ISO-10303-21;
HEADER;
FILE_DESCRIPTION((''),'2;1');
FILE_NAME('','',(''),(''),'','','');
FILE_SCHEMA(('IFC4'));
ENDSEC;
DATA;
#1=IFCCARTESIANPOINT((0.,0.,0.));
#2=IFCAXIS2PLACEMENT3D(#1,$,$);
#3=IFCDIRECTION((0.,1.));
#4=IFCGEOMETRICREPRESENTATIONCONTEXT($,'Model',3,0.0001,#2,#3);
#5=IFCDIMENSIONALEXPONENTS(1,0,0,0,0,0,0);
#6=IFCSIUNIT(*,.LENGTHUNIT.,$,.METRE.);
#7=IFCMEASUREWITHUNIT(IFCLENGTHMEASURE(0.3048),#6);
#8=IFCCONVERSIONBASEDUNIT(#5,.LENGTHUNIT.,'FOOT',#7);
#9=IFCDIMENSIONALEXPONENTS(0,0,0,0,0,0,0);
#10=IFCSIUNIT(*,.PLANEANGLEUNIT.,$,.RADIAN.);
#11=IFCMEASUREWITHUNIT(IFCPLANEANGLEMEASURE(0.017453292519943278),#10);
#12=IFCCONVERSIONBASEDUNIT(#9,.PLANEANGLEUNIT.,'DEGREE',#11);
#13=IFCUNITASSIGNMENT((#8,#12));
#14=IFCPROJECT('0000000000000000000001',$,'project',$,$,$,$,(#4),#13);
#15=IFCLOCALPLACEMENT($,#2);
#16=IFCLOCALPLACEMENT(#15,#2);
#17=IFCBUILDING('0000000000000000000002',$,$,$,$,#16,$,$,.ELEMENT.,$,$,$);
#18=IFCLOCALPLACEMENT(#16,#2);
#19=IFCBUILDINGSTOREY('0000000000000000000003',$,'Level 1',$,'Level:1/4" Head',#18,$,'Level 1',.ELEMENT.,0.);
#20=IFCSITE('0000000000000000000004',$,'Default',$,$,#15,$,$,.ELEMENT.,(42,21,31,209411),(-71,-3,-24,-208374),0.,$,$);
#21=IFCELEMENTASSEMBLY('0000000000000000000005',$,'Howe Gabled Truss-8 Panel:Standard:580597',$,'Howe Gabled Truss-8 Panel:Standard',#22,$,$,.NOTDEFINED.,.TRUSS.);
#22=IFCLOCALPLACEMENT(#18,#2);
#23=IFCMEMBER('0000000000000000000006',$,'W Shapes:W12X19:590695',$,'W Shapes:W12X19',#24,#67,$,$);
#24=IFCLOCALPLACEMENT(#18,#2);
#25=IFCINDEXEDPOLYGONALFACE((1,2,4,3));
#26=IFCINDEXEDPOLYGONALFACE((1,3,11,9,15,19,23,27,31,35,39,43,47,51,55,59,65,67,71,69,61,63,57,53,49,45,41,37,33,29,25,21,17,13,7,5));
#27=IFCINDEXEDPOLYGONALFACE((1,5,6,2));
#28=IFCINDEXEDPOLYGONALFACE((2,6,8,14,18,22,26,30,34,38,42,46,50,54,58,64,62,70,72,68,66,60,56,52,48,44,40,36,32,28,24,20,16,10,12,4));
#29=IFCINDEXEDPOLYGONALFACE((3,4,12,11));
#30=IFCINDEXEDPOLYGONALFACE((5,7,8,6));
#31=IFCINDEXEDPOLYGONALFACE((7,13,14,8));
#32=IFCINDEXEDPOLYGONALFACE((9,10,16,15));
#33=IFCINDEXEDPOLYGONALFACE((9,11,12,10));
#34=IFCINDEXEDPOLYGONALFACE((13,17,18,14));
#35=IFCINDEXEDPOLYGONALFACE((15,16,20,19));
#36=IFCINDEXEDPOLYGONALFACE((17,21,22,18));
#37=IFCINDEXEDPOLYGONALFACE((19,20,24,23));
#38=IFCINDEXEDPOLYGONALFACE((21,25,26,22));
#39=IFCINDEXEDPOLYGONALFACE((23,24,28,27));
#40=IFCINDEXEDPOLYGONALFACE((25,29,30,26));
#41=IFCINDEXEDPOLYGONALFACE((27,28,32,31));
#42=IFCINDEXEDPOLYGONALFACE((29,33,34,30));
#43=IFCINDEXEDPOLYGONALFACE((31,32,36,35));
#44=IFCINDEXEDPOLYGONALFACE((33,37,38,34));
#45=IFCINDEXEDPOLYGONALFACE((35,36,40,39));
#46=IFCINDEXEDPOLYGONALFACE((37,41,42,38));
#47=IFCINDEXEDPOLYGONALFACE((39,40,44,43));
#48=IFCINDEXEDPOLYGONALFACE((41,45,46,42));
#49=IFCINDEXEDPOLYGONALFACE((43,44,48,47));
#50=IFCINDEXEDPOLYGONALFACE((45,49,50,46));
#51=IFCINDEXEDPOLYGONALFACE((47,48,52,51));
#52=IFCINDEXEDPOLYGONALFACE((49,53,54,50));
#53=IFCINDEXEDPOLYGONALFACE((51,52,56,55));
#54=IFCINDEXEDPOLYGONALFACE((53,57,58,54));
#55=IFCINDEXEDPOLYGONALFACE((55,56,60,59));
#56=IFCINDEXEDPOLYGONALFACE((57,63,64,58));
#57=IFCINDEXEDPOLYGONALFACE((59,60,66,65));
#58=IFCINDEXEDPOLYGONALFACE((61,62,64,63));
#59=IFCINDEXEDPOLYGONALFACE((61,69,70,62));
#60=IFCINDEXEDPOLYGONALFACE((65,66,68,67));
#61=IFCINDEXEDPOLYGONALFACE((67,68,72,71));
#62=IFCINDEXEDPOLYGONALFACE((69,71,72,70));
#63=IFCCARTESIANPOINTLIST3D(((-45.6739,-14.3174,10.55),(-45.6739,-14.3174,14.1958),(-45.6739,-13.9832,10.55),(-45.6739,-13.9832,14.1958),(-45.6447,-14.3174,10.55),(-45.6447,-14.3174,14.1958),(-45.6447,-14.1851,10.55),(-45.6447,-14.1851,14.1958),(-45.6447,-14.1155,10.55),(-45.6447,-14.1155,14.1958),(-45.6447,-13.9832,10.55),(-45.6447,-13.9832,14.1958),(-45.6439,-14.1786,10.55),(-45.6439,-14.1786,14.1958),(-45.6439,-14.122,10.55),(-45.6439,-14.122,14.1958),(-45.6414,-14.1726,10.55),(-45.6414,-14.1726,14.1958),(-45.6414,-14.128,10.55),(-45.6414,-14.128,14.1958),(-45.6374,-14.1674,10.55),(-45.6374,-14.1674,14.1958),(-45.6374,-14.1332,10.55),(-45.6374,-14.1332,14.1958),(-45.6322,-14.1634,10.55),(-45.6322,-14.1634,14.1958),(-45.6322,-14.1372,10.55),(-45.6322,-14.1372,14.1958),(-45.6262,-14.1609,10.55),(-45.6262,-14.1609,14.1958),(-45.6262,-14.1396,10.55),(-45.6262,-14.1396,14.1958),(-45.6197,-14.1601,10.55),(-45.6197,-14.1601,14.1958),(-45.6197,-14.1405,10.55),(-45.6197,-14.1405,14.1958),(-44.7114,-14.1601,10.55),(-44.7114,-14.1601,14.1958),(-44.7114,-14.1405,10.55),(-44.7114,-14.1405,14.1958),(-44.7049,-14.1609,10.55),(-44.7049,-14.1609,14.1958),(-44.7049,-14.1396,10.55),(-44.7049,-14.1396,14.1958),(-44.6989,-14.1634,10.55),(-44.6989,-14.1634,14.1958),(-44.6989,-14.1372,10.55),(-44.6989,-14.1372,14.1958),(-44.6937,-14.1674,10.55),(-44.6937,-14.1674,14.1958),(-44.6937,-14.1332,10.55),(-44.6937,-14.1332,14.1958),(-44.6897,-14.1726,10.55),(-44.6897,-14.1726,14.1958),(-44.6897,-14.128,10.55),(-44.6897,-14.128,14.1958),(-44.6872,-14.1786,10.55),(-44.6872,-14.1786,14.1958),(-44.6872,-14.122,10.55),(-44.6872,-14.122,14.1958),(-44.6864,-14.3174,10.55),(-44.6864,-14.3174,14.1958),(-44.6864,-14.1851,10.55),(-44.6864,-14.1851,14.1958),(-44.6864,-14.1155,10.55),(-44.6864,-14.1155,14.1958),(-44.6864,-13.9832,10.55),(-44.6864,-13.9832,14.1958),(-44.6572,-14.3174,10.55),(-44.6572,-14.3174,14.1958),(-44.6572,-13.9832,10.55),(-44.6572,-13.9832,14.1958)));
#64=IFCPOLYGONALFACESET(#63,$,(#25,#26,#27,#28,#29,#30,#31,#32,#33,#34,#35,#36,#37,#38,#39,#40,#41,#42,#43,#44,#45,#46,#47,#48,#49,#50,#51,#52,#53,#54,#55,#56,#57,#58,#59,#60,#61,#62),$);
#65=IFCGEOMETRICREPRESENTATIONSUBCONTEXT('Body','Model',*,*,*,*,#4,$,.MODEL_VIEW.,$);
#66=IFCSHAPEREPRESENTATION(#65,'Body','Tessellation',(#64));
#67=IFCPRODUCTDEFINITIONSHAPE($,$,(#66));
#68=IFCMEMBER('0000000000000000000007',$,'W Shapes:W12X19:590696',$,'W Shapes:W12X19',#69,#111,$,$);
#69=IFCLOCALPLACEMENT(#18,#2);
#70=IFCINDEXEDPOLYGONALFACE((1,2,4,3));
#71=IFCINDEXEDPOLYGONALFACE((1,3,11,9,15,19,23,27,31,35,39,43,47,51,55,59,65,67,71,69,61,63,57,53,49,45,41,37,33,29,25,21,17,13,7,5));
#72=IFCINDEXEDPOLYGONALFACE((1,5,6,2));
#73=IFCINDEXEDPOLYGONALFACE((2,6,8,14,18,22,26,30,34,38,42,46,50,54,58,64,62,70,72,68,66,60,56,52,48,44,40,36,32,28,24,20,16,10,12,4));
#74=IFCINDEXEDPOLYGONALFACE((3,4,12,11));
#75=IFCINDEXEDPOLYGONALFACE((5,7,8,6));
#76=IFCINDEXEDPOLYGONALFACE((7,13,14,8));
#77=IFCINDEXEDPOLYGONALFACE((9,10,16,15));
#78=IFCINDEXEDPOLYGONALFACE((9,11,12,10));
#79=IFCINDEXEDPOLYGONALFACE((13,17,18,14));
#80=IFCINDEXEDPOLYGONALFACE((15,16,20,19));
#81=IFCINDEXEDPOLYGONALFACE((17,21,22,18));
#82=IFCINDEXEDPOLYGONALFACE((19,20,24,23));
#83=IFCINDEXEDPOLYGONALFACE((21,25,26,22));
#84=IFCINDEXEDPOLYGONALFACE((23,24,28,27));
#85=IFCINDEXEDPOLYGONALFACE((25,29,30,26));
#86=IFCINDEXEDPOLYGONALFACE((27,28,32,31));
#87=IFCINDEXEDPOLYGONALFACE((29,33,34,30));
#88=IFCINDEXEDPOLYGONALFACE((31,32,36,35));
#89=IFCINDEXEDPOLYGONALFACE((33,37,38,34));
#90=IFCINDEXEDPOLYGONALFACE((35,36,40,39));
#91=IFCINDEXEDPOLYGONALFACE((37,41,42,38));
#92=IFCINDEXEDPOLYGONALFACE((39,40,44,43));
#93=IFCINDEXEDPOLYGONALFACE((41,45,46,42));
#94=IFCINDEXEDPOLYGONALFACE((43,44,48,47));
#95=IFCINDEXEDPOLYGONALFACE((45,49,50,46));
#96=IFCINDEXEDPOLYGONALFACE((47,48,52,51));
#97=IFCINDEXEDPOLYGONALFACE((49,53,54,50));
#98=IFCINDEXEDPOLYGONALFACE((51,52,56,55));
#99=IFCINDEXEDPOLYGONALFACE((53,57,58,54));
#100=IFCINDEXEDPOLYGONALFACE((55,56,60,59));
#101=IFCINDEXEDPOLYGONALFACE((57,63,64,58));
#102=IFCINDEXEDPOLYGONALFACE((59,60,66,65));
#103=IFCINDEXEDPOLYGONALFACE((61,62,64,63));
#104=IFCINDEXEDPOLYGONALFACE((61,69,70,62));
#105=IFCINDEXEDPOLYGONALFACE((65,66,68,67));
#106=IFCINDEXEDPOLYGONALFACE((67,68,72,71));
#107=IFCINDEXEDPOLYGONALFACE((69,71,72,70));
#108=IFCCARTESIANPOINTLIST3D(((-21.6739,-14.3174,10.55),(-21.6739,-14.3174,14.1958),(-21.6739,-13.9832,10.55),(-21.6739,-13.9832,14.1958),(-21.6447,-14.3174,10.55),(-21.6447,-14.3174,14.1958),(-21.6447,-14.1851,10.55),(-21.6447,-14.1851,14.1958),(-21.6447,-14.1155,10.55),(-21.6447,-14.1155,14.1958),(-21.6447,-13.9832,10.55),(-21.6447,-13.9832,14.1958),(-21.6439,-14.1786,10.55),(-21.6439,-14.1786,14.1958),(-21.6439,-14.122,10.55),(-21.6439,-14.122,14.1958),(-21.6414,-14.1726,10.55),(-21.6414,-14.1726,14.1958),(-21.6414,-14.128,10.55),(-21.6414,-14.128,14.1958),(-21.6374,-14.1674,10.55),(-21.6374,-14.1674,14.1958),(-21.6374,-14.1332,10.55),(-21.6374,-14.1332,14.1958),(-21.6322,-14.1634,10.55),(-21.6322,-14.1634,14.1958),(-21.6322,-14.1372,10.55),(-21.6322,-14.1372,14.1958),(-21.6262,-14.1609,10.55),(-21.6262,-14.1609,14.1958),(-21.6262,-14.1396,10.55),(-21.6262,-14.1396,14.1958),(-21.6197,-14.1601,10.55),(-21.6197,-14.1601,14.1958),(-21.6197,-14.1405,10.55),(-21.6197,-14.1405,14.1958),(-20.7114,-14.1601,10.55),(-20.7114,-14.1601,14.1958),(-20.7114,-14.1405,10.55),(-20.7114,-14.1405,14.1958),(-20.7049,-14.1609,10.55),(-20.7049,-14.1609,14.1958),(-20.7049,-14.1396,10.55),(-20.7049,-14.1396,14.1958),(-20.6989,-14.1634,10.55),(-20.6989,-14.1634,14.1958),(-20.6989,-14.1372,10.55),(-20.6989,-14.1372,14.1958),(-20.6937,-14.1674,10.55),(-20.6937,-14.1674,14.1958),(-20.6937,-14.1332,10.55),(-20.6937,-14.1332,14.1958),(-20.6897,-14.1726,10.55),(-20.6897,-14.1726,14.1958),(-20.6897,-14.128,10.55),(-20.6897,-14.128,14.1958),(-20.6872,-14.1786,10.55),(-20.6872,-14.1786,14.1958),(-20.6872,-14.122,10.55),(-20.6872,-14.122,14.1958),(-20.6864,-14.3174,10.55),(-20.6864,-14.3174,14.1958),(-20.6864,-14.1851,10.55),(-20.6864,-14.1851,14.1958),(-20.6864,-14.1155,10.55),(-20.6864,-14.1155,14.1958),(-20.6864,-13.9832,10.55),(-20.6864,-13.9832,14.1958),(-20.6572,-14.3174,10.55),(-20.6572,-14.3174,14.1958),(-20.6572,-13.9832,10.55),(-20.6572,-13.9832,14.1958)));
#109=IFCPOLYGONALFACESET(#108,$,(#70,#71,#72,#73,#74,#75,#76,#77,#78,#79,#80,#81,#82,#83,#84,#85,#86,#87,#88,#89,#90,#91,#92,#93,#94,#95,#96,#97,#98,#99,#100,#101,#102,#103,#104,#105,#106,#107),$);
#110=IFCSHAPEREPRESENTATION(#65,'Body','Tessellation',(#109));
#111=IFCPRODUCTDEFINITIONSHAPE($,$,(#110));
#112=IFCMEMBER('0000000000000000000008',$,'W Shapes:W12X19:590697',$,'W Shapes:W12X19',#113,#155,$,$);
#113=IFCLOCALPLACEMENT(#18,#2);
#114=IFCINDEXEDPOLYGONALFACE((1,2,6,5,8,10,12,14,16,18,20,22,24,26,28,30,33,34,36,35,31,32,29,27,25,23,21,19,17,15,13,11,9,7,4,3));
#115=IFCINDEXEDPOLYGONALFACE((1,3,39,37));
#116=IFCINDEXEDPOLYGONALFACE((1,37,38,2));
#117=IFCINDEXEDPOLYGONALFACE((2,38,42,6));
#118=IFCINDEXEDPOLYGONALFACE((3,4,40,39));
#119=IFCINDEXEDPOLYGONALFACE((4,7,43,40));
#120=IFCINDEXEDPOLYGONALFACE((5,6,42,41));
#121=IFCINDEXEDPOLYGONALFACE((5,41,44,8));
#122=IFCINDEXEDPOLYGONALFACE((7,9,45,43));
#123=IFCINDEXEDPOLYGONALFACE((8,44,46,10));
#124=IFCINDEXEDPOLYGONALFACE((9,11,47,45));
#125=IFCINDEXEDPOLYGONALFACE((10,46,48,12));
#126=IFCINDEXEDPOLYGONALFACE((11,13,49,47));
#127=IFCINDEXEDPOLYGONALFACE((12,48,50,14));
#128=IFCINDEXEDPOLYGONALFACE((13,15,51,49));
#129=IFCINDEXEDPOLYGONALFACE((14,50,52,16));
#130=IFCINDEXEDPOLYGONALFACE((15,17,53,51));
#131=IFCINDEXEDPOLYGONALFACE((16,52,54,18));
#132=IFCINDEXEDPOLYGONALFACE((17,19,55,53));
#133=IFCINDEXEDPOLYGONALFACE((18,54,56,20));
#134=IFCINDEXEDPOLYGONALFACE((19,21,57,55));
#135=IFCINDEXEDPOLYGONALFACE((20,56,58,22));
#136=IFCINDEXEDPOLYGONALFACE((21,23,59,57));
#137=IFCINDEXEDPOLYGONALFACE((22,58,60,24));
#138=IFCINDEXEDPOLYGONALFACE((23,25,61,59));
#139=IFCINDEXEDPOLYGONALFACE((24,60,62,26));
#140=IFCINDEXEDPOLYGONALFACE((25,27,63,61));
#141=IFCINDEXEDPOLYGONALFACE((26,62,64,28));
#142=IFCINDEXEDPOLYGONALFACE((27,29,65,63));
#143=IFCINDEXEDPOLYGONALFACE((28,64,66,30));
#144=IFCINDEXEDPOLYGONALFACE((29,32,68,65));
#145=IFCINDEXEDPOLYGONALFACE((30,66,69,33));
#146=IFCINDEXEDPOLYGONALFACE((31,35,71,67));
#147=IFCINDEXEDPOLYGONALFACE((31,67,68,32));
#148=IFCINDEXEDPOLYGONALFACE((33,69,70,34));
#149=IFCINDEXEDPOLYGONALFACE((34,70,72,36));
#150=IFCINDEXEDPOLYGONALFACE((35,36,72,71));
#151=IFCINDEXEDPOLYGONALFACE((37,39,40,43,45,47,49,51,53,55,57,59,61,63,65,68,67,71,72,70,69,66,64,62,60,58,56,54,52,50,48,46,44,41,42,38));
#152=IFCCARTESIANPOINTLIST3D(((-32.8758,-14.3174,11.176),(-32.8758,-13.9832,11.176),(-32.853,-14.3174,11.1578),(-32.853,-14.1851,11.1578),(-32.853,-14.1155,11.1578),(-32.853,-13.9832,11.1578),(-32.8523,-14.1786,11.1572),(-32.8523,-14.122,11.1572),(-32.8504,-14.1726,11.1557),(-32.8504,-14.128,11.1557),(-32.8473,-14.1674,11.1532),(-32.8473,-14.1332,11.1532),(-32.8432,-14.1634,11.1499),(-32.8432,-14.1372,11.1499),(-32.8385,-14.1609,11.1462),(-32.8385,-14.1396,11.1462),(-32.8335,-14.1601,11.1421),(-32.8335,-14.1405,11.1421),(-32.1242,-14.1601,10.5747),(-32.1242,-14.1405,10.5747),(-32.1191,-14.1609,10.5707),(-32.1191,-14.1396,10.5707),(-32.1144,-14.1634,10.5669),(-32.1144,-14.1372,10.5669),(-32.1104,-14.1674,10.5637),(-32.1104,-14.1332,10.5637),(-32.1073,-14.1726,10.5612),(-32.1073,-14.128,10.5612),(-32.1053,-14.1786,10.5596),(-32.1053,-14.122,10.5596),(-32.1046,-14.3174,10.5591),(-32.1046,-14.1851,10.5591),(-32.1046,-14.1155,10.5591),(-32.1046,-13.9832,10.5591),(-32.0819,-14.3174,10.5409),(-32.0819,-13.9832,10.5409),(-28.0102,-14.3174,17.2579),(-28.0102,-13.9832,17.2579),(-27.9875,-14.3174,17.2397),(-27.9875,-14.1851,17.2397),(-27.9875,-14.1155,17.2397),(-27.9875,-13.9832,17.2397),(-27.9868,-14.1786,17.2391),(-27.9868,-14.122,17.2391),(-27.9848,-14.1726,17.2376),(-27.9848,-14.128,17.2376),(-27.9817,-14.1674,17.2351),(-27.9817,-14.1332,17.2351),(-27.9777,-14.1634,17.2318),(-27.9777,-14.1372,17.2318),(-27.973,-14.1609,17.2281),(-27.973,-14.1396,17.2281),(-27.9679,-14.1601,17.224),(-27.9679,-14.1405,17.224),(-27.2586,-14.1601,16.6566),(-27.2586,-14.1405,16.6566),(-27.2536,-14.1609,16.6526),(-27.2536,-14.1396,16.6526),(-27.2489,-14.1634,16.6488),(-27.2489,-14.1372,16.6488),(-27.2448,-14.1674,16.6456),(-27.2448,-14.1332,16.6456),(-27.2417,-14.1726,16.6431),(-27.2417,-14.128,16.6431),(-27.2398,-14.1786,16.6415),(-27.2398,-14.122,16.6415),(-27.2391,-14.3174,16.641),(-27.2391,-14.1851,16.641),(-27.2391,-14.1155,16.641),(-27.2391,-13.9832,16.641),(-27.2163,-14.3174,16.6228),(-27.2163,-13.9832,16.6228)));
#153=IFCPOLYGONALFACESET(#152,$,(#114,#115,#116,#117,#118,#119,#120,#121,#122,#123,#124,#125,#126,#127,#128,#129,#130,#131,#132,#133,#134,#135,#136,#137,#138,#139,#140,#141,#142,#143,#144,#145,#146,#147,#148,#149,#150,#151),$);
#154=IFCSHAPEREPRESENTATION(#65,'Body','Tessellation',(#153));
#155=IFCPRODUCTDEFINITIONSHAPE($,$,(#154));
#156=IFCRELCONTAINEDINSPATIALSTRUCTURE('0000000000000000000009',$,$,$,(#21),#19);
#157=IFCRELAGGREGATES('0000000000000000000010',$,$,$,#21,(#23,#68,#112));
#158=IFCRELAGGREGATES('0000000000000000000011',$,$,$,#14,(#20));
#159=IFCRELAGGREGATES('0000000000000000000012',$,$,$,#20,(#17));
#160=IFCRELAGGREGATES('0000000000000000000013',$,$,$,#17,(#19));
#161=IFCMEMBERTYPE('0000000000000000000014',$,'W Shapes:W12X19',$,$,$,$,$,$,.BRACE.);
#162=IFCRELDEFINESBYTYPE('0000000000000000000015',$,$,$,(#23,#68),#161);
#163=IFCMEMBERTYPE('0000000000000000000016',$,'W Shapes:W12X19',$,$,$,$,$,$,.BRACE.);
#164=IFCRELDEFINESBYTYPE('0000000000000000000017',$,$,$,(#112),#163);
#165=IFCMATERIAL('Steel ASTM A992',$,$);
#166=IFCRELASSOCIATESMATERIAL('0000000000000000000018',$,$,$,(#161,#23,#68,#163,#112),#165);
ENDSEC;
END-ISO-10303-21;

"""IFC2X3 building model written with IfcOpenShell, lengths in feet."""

from ifc_helpers import new_model, entity, si_unit, converted_unit, direction, frame, frame_2d, origin, place, context, subcontext, project, spatial, polyline, circle_curve, parameter, trimmed, segment, composite_curve, outline, extrude, source, transform, mapped, material, type_object, type_shapes, element, aggregate, save


model = new_model("IFC2X3")

# Units and contexts
model_context = context("Model", 3, precision=0.0001, world=origin(), true_north=direction((0.0, 1.0)))
body_context = subcontext(model_context, "Body", "Model", "MODEL_VIEW")
ifc_project = project(units=[converted_unit("LENGTHUNIT", "FOOT", entity("IfcLengthMeasure", 0.3048), si_unit("LENGTHUNIT", "METRE"), dimensions=[1, 0, 0, 0, 0, 0, 0]), converted_unit("PLANEANGLEUNIT", "DEGREE", entity("IfcPlaneAngleMeasure", 0.017453292519943278), si_unit("PLANEANGLEUNIT", "RADIAN"), dimensions=[0, 0, 0, 0, 0, 0, 0])], contexts=[model_context])

# Site, building, storey
site_placement = place(None, origin())
site = spatial("IfcSite", under=ifc_project, at=site_placement, Name="Default", CompositionType="ELEMENT", RefLatitude=(42, 21, 31, 209411), RefLongitude=(-71, -3, -24, -208374), RefElevation=0.0)
building_placement = place(site_placement, origin())
building = spatial("IfcBuilding", under=site, at=building_placement, CompositionType="ELEMENT")
storey_placement = place(building_placement, origin())
storey = spatial("IfcBuildingStorey", under=building, at=storey_placement, Name="Level 1", ObjectType="Level:1/4\" Head", LongName="Level 1", CompositionType="ELEMENT", Elevation=0.0)

# Element assembly, members
assembly_placement = place(storey_placement, origin())
assembly = element("IfcElementAssembly", 1, at=assembly_placement, inside=storey, Name="Howe Gabled Truss-8 Panel:Standard:580597", ObjectType="Howe Gabled Truss-8 Panel:Standard", AssemblyPlace="NOTDEFINED", PredefinedType="TRUSS")
ifc_material = material(Name="Steel ASTM A992")
member_type_1 = type_object("IfcMemberType", Name="W Shapes:W12X19", PredefinedType="BRACE", material=ifc_material)
shared_shape_1 = source(origin(), body_context, "Body", "SweptSolid", [
    extrude(outline(composite_curve([segment(polyline([(-0.1671, -0.4792), (-0.1671, -0.5083)]), True, "CONTINUOUS"), segment(polyline([(-0.1671, -0.5083), (0.1671, -0.5083)]), True, "CONTINUOUS"), segment(polyline([(0.1671, -0.5083), (0.1671, -0.4792)]), True, "CONTINUOUS"), segment(polyline([(0.1671, -0.4792), (0.0348, -0.4792)]), True, "CONTINUOUS"), segment(trimmed(circle_curve(frame_2d((0.0348, -0.4542), x_axis=(0.0, -1.0)), 0.025), [parameter(270.0)], [parameter(360.0)], True, "PARAMETER"), False, "CONTINUOUS"), segment(polyline([(0.0098, -0.4542), (0.0098, 0.4542)]), True, "CONTINUOUS"), segment(trimmed(circle_curve(frame_2d((0.0348, 0.4542), x_axis=(-1.0, 0.0)), 0.025), [parameter(270.0)], [parameter(360.0)], True, "PARAMETER"), False, "CONTINUOUS"), segment(polyline([(0.0348, 0.4792), (0.1671, 0.4792)]), True, "CONTINUOUS"), segment(polyline([(0.1671, 0.4792), (0.1671, 0.5083)]), True, "CONTINUOUS"), segment(polyline([(0.1671, 0.5083), (-0.1671, 0.5083)]), True, "CONTINUOUS"), segment(polyline([(-0.1671, 0.5083), (-0.1671, 0.4792)]), True, "CONTINUOUS"), segment(polyline([(-0.1671, 0.4792), (-0.0348, 0.4792)]), True, "CONTINUOUS"), segment(trimmed(circle_curve(frame_2d((-0.0348, 0.4542), x_axis=(0.0, 1.0)), 0.025), [parameter(270.0)], [parameter(0.0)], True, "PARAMETER"), False, "CONTINUOUS"), segment(polyline([(-0.0098, 0.4542), (-0.0098, -0.4542)]), True, "CONTINUOUS"), segment(trimmed(circle_curve(frame_2d((-0.0348, -0.4542), x_axis=(1.0, 0.0)), 0.025), [parameter(270.0)], [parameter(0.0)], True, "PARAMETER"), False, "CONTINUOUS"), segment(polyline([(-0.0348, -0.4792), (-0.1671, -0.4792)]), True, "CONTINUOUS")], self_intersect=False)), frame((-1.95, 0.0, 0.0), z_axis=(-1.0, 0.0, 0.0), x_axis=(0.0, -1.0, 0.0)), (0.0, 0.0, -1.0), 3.6458),
])
type_shapes(member_type_1, [shared_shape_1])
member_1_placement = place(assembly_placement, frame((-45.1655, -14.1503, 12.5), z_axis=(1.0, 0.0, 0.0), x_axis=(0.0, 0.0, 1.0)))
member_1 = element("IfcMember", 2, at=member_1_placement, type_object=member_type_1, material=ifc_material, Name="W Shapes:W12X19:590695", ObjectType="W Shapes:W12X19", context=body_context, shape_type="MappedRepresentation", body=[
    mapped(shared_shape_1, transform((0.0, 0.0, 0.0), scale=1.0)),
])
member_2_placement = place(assembly_placement, frame((-21.1655, -14.1503, 12.5), z_axis=(1.0, 0.0, 0.0), x_axis=(0.0, 0.0, 1.0)))
member_2 = element("IfcMember", 3, at=member_2_placement, type_object=member_type_1, material=ifc_material, Name="W Shapes:W12X19:590696", ObjectType="W Shapes:W12X19", context=body_context, shape_type="MappedRepresentation", body=[
    mapped(shared_shape_1, transform((0.0, 0.0, 0.0), scale=1.0)),
])
member_type_2 = type_object("IfcMemberType", Name="W Shapes:W12X19", PredefinedType="BRACE", material=ifc_material)
shared_shape_2 = source(origin(), body_context, "Body", "SweptSolid", [
    extrude(outline(composite_curve([segment(polyline([(-0.1671, -0.4792), (-0.1671, -0.5083)]), True, "CONTINUOUS"), segment(polyline([(-0.1671, -0.5083), (0.1671, -0.5083)]), True, "CONTINUOUS"), segment(polyline([(0.1671, -0.5083), (0.1671, -0.4792)]), True, "CONTINUOUS"), segment(polyline([(0.1671, -0.4792), (0.0348, -0.4792)]), True, "CONTINUOUS"), segment(trimmed(circle_curve(frame_2d((0.0348, -0.4542), x_axis=(1.0, 0.0)), 0.025), [parameter(180.0)], [parameter(270.0)], True, "PARAMETER"), False, "CONTINUOUS"), segment(polyline([(0.0098, -0.4542), (0.0098, 0.4542)]), True, "CONTINUOUS"), segment(trimmed(circle_curve(frame_2d((0.0348, 0.4542), x_axis=(1.0, 0.0)), 0.025), [parameter(90.0)], [parameter(180.0)], True, "PARAMETER"), False, "CONTINUOUS"), segment(polyline([(0.0348, 0.4792), (0.1671, 0.4792)]), True, "CONTINUOUS"), segment(polyline([(0.1671, 0.4792), (0.1671, 0.5083)]), True, "CONTINUOUS"), segment(polyline([(0.1671, 0.5083), (-0.1671, 0.5083)]), True, "CONTINUOUS"), segment(polyline([(-0.1671, 0.5083), (-0.1671, 0.4792)]), True, "CONTINUOUS"), segment(polyline([(-0.1671, 0.4792), (-0.0348, 0.4792)]), True, "CONTINUOUS"), segment(trimmed(circle_curve(frame_2d((-0.0348, 0.4542), x_axis=(1.0, 0.0)), 0.025), [parameter(360.0)], [parameter(90.0)], True, "PARAMETER"), False, "CONTINUOUS"), segment(polyline([(-0.0098, 0.4542), (-0.0098, -0.4542)]), True, "CONTINUOUS"), segment(trimmed(circle_curve(frame_2d((-0.0348, -0.4542), x_axis=(1.0, 0.0)), 0.025), [parameter(270.0)], [parameter(360.0)], True, "PARAMETER"), False, "CONTINUOUS"), segment(polyline([(-0.0348, -0.4792), (-0.1671, -0.4792)]), True, "CONTINUOUS")], self_intersect=False)), frame((-3.703, 0.0, 0.0), z_axis=(-1.0, 0.0, 0.0), x_axis=(0.0, -1.0, 0.0)), (0.0, 0.0, -1.0), 7.7886),
])
type_shapes(member_type_2, [shared_shape_2])
member_3_placement = place(assembly_placement, frame((-30.1655, -14.1503, 13.75), z_axis=(0.780869, 0.0, -0.624695), x_axis=(0.624695, 0.0, 0.780869)))
member_3 = element("IfcMember", 4, at=member_3_placement, type_object=member_type_2, material=ifc_material, Name="W Shapes:W12X19:590697", ObjectType="W Shapes:W12X19", context=body_context, shape_type="MappedRepresentation", body=[
    mapped(shared_shape_2, transform((0.0, 0.0, 0.0), scale=1.0)),
])
aggregate(assembly, [member_1, member_2, member_3])

save(model, "model.ifc")
